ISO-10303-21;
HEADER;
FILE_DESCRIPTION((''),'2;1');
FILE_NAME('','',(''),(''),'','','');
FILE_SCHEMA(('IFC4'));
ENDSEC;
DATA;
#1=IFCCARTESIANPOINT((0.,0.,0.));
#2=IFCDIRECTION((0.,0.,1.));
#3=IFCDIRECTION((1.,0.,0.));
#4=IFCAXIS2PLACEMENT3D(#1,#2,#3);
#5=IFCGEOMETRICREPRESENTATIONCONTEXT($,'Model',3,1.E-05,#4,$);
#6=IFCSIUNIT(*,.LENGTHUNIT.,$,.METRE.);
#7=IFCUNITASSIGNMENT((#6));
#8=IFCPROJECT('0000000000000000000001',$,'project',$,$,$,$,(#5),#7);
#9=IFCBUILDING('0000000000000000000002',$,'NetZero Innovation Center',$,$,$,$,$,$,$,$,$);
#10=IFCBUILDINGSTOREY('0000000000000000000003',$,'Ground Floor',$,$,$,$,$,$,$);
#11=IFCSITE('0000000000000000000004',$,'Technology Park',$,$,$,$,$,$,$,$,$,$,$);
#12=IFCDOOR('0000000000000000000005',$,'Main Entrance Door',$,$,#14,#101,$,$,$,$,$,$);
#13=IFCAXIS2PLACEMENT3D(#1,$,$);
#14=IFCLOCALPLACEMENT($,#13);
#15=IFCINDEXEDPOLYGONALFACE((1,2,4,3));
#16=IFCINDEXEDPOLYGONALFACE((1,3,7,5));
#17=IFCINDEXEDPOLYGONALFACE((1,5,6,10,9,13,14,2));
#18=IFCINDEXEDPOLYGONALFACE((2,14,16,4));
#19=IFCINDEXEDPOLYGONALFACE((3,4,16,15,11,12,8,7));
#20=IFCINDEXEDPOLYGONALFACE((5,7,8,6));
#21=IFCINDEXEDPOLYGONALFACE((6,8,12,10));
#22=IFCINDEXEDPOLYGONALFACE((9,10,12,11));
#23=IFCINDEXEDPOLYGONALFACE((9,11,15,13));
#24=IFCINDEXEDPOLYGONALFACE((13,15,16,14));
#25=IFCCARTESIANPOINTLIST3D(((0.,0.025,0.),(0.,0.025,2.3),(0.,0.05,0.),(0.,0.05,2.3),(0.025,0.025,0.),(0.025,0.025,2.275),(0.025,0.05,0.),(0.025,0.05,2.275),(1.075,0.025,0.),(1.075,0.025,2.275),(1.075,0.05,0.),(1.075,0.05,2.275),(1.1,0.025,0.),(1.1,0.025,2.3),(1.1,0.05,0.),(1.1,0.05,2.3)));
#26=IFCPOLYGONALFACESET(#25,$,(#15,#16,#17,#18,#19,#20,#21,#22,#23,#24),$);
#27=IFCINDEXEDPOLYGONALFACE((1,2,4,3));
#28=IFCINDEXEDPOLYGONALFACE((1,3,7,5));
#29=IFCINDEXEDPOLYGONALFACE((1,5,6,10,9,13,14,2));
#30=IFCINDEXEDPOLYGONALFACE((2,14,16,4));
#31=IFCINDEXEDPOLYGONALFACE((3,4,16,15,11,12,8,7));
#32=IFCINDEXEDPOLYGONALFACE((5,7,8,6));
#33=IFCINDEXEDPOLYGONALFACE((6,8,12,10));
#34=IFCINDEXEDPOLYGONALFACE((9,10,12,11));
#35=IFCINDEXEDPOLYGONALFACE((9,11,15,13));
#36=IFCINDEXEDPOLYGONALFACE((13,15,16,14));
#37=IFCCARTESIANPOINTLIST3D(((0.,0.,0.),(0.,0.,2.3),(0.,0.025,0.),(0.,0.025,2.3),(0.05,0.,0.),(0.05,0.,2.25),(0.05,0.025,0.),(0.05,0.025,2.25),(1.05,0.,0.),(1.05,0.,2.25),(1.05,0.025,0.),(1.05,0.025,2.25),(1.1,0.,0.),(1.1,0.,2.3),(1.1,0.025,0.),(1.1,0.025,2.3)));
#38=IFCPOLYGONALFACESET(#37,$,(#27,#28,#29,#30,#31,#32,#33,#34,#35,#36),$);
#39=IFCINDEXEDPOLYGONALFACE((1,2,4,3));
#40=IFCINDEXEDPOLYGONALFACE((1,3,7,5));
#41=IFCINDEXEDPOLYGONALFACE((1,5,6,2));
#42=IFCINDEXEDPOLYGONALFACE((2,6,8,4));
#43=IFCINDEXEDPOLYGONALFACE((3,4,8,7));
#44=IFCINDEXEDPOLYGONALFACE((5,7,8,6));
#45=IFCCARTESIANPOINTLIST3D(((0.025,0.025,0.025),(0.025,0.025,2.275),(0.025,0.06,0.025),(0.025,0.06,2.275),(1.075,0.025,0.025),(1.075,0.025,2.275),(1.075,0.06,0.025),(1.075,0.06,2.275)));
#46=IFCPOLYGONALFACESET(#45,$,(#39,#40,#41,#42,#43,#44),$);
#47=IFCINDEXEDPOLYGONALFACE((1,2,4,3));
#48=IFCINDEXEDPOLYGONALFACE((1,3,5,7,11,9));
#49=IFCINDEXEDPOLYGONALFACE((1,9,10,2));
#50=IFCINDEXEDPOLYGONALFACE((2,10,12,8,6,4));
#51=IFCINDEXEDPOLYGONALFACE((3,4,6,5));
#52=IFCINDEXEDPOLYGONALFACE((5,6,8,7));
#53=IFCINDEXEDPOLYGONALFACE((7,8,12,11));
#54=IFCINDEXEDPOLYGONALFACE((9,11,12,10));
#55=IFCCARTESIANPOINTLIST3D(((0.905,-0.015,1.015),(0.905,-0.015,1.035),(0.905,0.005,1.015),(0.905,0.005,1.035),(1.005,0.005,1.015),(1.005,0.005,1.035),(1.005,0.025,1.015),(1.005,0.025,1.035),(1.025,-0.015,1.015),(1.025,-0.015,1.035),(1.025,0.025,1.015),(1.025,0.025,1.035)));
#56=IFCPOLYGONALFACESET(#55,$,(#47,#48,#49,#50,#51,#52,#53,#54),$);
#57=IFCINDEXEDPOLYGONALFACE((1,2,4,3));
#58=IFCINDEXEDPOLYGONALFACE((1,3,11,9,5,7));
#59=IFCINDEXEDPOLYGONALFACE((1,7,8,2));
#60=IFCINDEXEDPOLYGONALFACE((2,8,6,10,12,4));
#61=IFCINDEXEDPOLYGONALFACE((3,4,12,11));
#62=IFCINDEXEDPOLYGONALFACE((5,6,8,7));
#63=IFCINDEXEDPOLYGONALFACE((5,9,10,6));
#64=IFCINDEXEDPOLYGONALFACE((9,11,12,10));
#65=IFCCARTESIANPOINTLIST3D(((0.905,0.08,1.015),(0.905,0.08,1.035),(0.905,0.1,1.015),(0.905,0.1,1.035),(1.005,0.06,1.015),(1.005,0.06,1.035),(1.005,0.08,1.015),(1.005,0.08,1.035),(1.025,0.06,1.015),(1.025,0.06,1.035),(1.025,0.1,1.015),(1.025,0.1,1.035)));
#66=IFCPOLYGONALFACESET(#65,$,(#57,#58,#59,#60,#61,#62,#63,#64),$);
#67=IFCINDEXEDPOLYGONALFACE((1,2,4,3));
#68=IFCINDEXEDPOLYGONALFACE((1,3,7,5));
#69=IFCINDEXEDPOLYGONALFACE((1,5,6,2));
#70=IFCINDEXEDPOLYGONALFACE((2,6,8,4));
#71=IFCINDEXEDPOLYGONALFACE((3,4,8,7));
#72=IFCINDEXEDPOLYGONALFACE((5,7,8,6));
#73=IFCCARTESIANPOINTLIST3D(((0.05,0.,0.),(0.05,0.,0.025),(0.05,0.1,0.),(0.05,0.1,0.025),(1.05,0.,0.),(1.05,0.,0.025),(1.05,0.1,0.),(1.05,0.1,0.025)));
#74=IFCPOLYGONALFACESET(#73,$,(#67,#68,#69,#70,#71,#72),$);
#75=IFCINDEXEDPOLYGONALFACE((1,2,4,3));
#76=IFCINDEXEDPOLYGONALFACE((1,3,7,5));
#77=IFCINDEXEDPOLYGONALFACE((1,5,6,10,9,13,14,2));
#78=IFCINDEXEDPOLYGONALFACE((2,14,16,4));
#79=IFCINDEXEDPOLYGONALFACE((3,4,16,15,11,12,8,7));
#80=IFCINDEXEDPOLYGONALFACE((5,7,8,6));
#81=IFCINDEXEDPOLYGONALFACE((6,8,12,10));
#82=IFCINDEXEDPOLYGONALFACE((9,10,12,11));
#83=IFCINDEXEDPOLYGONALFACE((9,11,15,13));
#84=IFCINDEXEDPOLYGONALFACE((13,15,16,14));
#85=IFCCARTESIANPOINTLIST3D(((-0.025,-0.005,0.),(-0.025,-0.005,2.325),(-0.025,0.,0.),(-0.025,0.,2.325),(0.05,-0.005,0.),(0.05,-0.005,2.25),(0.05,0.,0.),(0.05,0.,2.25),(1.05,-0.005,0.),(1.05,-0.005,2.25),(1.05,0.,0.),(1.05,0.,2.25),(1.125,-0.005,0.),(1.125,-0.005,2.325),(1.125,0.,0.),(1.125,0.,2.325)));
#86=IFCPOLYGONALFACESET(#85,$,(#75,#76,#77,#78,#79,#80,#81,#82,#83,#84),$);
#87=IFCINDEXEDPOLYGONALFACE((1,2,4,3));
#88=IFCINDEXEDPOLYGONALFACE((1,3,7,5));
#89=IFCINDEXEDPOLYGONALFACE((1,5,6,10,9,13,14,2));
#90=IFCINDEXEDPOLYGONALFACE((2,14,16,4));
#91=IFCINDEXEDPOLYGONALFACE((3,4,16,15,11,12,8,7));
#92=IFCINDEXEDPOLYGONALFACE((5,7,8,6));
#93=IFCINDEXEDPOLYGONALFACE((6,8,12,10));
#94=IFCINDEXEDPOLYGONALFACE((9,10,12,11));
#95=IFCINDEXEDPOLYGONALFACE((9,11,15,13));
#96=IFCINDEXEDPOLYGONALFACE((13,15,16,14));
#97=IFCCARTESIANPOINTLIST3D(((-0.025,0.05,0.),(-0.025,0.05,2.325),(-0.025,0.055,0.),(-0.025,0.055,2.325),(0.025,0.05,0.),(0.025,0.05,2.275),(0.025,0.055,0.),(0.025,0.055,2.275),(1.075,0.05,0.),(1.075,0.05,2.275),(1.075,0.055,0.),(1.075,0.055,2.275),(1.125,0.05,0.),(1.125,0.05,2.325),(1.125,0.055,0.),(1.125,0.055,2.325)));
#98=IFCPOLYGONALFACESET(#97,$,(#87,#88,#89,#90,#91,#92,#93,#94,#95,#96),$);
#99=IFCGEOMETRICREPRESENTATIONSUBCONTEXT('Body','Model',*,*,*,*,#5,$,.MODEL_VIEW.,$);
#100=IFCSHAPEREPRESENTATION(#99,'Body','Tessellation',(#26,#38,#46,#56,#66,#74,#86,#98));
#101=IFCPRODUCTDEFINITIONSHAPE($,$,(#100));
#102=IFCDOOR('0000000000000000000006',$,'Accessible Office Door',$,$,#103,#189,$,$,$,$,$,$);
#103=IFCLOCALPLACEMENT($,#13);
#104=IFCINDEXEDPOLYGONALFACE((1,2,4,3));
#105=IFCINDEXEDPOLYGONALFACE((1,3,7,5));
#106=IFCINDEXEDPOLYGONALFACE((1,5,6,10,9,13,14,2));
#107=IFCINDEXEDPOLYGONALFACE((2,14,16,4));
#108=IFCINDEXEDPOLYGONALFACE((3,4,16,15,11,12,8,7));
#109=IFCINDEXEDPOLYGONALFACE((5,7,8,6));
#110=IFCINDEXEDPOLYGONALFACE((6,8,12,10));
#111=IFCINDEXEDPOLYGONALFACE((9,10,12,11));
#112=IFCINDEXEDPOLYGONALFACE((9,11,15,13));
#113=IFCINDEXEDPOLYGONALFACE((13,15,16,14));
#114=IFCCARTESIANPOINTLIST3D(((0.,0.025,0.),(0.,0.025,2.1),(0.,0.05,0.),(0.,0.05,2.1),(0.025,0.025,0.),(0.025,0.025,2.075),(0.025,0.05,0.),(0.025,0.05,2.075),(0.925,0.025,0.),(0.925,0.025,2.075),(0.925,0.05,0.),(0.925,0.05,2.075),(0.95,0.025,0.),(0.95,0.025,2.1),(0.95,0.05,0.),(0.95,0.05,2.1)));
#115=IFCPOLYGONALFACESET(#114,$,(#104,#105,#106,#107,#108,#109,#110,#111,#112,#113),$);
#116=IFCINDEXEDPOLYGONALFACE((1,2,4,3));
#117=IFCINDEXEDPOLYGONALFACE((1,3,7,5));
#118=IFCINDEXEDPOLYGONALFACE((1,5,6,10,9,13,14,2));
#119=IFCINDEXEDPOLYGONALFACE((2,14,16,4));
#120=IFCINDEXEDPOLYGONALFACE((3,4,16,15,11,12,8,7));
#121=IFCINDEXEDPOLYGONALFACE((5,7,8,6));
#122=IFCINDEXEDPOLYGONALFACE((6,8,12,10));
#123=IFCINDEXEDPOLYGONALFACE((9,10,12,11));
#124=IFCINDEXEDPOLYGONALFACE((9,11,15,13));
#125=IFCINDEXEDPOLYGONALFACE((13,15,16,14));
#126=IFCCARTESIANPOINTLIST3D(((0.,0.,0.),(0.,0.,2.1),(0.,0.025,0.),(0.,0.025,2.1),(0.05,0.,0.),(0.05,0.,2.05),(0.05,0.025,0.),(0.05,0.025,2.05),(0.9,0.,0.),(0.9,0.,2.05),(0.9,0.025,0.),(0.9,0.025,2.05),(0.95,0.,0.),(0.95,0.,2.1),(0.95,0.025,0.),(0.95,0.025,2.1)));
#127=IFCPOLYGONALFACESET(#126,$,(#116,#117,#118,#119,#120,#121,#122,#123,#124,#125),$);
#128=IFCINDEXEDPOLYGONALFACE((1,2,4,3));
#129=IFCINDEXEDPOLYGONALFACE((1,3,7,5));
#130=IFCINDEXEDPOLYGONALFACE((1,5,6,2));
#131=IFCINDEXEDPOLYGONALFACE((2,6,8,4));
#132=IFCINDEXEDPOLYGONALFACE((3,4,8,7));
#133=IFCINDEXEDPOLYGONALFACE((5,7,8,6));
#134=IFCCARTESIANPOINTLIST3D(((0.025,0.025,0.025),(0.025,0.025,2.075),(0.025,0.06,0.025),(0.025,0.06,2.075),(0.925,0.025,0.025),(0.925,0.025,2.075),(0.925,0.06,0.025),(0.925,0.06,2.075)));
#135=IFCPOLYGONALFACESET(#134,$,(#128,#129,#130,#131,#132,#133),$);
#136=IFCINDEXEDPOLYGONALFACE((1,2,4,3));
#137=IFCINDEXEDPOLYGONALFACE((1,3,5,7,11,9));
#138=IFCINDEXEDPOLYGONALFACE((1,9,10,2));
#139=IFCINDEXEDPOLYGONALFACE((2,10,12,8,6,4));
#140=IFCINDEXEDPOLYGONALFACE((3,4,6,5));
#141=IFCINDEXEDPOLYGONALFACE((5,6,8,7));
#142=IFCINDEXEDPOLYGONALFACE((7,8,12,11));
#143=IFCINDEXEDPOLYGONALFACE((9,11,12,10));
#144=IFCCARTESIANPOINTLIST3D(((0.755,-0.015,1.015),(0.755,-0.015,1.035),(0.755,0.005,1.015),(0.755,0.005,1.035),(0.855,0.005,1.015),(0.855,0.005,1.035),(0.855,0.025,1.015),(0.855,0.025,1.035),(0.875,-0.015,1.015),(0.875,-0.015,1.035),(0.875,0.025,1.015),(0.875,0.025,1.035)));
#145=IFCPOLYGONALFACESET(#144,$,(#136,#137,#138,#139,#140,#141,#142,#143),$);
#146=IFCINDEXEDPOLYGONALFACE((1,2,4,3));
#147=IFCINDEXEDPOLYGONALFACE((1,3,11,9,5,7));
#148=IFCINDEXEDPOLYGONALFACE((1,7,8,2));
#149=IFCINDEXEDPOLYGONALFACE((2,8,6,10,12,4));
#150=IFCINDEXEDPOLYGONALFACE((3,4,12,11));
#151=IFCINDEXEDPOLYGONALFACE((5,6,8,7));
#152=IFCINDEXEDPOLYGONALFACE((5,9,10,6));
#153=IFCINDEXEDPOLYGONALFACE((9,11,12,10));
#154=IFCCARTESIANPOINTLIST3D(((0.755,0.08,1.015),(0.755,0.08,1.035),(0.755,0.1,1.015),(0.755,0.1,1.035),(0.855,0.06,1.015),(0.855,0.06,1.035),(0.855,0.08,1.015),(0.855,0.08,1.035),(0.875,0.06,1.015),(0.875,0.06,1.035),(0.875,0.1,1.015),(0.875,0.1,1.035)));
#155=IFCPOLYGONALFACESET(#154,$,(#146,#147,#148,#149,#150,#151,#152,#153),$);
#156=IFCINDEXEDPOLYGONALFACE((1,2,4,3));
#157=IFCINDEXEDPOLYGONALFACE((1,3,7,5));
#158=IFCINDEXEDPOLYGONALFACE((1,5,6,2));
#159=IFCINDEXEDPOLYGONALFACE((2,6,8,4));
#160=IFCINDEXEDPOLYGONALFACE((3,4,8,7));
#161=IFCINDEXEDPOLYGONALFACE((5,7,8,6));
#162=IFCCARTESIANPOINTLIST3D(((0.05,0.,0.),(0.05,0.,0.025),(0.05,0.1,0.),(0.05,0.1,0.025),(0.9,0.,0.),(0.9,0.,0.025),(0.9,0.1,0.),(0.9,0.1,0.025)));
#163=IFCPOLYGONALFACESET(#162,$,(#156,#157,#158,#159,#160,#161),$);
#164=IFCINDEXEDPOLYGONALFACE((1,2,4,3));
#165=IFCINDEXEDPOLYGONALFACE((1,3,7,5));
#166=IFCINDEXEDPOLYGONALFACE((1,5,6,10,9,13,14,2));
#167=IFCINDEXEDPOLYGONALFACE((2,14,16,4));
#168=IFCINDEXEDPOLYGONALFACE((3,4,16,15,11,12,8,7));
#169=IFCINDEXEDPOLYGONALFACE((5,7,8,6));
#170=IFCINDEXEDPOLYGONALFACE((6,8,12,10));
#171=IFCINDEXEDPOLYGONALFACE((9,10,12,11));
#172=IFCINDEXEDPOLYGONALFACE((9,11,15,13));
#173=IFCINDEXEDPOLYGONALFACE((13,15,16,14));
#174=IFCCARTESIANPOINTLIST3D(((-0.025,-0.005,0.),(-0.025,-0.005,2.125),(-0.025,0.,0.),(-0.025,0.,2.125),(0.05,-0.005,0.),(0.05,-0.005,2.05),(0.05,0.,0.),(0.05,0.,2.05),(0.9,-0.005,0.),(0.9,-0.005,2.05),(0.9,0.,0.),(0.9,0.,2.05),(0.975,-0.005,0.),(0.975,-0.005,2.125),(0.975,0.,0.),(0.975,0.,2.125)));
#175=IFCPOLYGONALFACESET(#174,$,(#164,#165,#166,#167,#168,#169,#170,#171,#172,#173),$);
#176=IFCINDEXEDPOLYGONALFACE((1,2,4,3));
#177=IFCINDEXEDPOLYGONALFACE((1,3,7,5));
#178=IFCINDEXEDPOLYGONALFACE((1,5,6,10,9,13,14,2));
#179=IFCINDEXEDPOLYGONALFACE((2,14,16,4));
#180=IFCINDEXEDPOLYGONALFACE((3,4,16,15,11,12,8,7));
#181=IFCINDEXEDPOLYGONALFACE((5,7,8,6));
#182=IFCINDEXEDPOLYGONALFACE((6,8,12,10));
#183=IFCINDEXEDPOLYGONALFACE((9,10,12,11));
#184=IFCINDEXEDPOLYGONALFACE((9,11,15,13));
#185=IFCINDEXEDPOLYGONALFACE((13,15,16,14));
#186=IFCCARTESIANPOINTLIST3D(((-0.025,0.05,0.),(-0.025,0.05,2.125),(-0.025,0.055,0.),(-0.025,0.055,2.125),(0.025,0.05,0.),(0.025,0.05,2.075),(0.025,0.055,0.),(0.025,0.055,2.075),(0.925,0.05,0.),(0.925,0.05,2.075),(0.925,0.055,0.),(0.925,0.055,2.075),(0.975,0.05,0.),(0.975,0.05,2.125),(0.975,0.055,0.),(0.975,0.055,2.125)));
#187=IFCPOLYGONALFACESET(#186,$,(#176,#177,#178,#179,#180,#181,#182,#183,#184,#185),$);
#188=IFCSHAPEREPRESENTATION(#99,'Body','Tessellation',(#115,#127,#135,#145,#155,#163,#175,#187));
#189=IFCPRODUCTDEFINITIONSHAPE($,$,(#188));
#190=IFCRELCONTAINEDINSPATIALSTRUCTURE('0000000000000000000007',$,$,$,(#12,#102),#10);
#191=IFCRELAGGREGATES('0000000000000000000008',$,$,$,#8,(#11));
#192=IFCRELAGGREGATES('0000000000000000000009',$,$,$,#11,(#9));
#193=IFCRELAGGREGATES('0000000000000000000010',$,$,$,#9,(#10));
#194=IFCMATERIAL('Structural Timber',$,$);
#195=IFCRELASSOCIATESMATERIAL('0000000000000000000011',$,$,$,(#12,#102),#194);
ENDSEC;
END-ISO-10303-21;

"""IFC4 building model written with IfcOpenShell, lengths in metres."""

from ifc_helpers import new_model, si_unit, frame, origin_with_axes, context, subcontext, project, spatial, line, indexed_curve, outline, extrude, material, element, save


model = new_model("IFC4")

# Units and contexts
model_context = context("Model", 3, precision=1e-05, world=origin_with_axes())
body_context = subcontext(model_context, "Body", "Model", "MODEL_VIEW")
ifc_project = project(units=[si_unit("LENGTHUNIT", "METRE")], contexts=[model_context])

# Site, building, storey
site = spatial("IfcSite", under=ifc_project, Name="Technology Park")
building = spatial("IfcBuilding", under=site, Name="NetZero Innovation Center")
storey = spatial("IfcBuildingStorey", under=building, Name="Ground Floor")

# Doors
ifc_material_1 = material(Name="Structural Timber")
element("IfcDoor", 1, inside=storey, material=ifc_material_1, Name="Main Entrance Door", context=body_context, shape_type="SweptSolid", body=[
    extrude(outline(indexed_curve([(0.0, 0.0), (0.0, 2.3), (1.1, 2.3), (1.1, 0.0), (1.075, 0.0), (1.075, 2.275), (0.025, 2.275), (0.025, 0.0)], segments=[line(1, 2, 3, 4, 5, 6, 7, 8, 1)])), frame((0.0, 0.025, 0.0), z_axis=(0.0, -1.0, 0.0), x_axis=(1.0, 0.0, 0.0)), (0.0, 0.0, -1.0), 0.025),
    extrude(outline(indexed_curve([(0.0, 0.0), (0.0, 2.3), (1.1, 2.3), (1.1, 0.0), (1.05, 0.0), (1.05, 2.25), (0.05, 2.25), (0.05, 0.0)], segments=[line(1, 2, 3, 4, 5, 6, 7, 8, 1)])), frame((0.0, 0.0, 0.0), z_axis=(0.0, -1.0, 0.0), x_axis=(1.0, 0.0, 0.0)), (0.0, 0.0, -1.0), 0.025),
    extrude(outline(indexed_curve([(0.0, 0.0), (1.05, 0.0), (1.05, 0.035), (0.0, 0.035)], segments=[line(1, 2, 3, 4, 1)])), frame((0.025, 0.025, 0.025), z_axis=(0.0, 0.0, 1.0), x_axis=(1.0, 0.0, 0.0)), (0.0, 0.0, 1.0), 2.25),
    extrude(outline(indexed_curve([(0.0, 0.0), (0.0, -0.04), (-0.12, -0.04), (-0.12, -0.02), (-0.02, -0.02), (-0.02, 0.0)], segments=[line(1, 2, 3, 4, 5, 6, 1)])), frame((1.025, 0.025, 1.015), z_axis=(0.0, 0.0, 1.0), x_axis=(1.0, 0.0, 0.0)), (0.0, 0.0, 1.0), 0.02),
    extrude(outline(indexed_curve([(0.0, 0.0), (0.0, 0.04), (-0.12, 0.04), (-0.12, 0.02), (-0.02, 0.02), (-0.02, 0.0)], segments=[line(1, 2, 3, 4, 5, 6, 1)])), frame((1.025, 0.06, 1.015), z_axis=(0.0, 0.0, 1.0), x_axis=(1.0, 0.0, 0.0)), (0.0, 0.0, 1.0), 0.02),
    extrude(outline(indexed_curve([(0.0, 0.0), (1.0, 0.0), (1.0, 0.1), (0.0, 0.1)], segments=[line(1, 2, 3, 4, 1)])), frame((0.05, 0.0, 0.0), z_axis=(0.0, 0.0, 1.0), x_axis=(1.0, 0.0, 0.0)), (0.0, 0.0, 1.0), 0.025),
    extrude(outline(indexed_curve([(0.0, 0.0), (0.0, 2.325), (1.15, 2.325), (1.15, 0.0), (1.075, 0.0), (1.075, 2.25), (0.075, 2.25), (0.075, 0.0)], segments=[line(1, 2, 3, 4, 5, 6, 7, 8, 1)])), frame((-0.025, -0.005, 0.0), z_axis=(0.0, -1.0, 0.0), x_axis=(1.0, 0.0, 0.0)), (0.0, 0.0, -1.0), 0.005),
    extrude(outline(indexed_curve([(0.0, 0.0), (0.0, 2.325), (1.15, 2.325), (1.15, 0.0), (1.1, 0.0), (1.1, 2.275), (0.05, 2.275), (0.05, 0.0)], segments=[line(1, 2, 3, 4, 5, 6, 7, 8, 1)])), frame((-0.025, 0.05, 0.0), z_axis=(0.0, -1.0, 0.0), x_axis=(1.0, 0.0, 0.0)), (0.0, 0.0, -1.0), 0.005),
])
element("IfcDoor", 2, inside=storey, material=ifc_material_1, Name="Accessible Office Door", context=body_context, shape_type="SweptSolid", body=[
    extrude(outline(indexed_curve([(0.0, 0.0), (0.0, 2.1), (0.95, 2.1), (0.95, 0.0), (0.925, 0.0), (0.925, 2.075), (0.025, 2.075), (0.025, 0.0)], segments=[line(1, 2, 3, 4, 5, 6, 7, 8, 1)])), frame((0.0, 0.025, 0.0), z_axis=(0.0, -1.0, 0.0), x_axis=(1.0, 0.0, 0.0)), (0.0, 0.0, -1.0), 0.025),
    extrude(outline(indexed_curve([(0.0, 0.0), (0.0, 2.1), (0.95, 2.1), (0.95, 0.0), (0.9, 0.0), (0.9, 2.05), (0.05, 2.05), (0.05, 0.0)], segments=[line(1, 2, 3, 4, 5, 6, 7, 8, 1)])), frame((0.0, 0.0, 0.0), z_axis=(0.0, -1.0, 0.0), x_axis=(1.0, 0.0, 0.0)), (0.0, 0.0, -1.0), 0.025),
    extrude(outline(indexed_curve([(0.0, 0.0), (0.9, 0.0), (0.9, 0.035), (0.0, 0.035)], segments=[line(1, 2, 3, 4, 1)])), frame((0.025, 0.025, 0.025), z_axis=(0.0, 0.0, 1.0), x_axis=(1.0, 0.0, 0.0)), (0.0, 0.0, 1.0), 2.05),
    extrude(outline(indexed_curve([(0.0, 0.0), (0.0, -0.04), (-0.12, -0.04), (-0.12, -0.02), (-0.02, -0.02), (-0.02, 0.0)], segments=[line(1, 2, 3, 4, 5, 6, 1)])), frame((0.875, 0.025, 1.015), z_axis=(0.0, 0.0, 1.0), x_axis=(1.0, 0.0, 0.0)), (0.0, 0.0, 1.0), 0.02),
    extrude(outline(indexed_curve([(0.0, 0.0), (0.0, 0.04), (-0.12, 0.04), (-0.12, 0.02), (-0.02, 0.02), (-0.02, 0.0)], segments=[line(1, 2, 3, 4, 5, 6, 1)])), frame((0.875, 0.06, 1.015), z_axis=(0.0, 0.0, 1.0), x_axis=(1.0, 0.0, 0.0)), (0.0, 0.0, 1.0), 0.02),
    extrude(outline(indexed_curve([(0.0, 0.0), (0.85, 0.0), (0.85, 0.1), (0.0, 0.1)], segments=[line(1, 2, 3, 4, 1)])), frame((0.05, 0.0, 0.0), z_axis=(0.0, 0.0, 1.0), x_axis=(1.0, 0.0, 0.0)), (0.0, 0.0, 1.0), 0.025),
    extrude(outline(indexed_curve([(0.0, 0.0), (0.0, 2.125), (1.0, 2.125), (1.0, 0.0), (0.925, 0.0), (0.925, 2.05), (0.075, 2.05), (0.075, 0.0)], segments=[line(1, 2, 3, 4, 5, 6, 7, 8, 1)])), frame((-0.025, -0.005, 0.0), z_axis=(0.0, -1.0, 0.0), x_axis=(1.0, 0.0, 0.0)), (0.0, 0.0, -1.0), 0.005),
    extrude(outline(indexed_curve([(0.0, 0.0), (0.0, 2.125), (1.0, 2.125), (1.0, 0.0), (0.95, 0.0), (0.95, 2.075), (0.05, 2.075), (0.05, 0.0)], segments=[line(1, 2, 3, 4, 5, 6, 7, 8, 1)])), frame((-0.025, 0.05, 0.0), z_axis=(0.0, -1.0, 0.0), x_axis=(1.0, 0.0, 0.0)), (0.0, 0.0, -1.0), 0.005),
])

save(model, "model.ifc")
